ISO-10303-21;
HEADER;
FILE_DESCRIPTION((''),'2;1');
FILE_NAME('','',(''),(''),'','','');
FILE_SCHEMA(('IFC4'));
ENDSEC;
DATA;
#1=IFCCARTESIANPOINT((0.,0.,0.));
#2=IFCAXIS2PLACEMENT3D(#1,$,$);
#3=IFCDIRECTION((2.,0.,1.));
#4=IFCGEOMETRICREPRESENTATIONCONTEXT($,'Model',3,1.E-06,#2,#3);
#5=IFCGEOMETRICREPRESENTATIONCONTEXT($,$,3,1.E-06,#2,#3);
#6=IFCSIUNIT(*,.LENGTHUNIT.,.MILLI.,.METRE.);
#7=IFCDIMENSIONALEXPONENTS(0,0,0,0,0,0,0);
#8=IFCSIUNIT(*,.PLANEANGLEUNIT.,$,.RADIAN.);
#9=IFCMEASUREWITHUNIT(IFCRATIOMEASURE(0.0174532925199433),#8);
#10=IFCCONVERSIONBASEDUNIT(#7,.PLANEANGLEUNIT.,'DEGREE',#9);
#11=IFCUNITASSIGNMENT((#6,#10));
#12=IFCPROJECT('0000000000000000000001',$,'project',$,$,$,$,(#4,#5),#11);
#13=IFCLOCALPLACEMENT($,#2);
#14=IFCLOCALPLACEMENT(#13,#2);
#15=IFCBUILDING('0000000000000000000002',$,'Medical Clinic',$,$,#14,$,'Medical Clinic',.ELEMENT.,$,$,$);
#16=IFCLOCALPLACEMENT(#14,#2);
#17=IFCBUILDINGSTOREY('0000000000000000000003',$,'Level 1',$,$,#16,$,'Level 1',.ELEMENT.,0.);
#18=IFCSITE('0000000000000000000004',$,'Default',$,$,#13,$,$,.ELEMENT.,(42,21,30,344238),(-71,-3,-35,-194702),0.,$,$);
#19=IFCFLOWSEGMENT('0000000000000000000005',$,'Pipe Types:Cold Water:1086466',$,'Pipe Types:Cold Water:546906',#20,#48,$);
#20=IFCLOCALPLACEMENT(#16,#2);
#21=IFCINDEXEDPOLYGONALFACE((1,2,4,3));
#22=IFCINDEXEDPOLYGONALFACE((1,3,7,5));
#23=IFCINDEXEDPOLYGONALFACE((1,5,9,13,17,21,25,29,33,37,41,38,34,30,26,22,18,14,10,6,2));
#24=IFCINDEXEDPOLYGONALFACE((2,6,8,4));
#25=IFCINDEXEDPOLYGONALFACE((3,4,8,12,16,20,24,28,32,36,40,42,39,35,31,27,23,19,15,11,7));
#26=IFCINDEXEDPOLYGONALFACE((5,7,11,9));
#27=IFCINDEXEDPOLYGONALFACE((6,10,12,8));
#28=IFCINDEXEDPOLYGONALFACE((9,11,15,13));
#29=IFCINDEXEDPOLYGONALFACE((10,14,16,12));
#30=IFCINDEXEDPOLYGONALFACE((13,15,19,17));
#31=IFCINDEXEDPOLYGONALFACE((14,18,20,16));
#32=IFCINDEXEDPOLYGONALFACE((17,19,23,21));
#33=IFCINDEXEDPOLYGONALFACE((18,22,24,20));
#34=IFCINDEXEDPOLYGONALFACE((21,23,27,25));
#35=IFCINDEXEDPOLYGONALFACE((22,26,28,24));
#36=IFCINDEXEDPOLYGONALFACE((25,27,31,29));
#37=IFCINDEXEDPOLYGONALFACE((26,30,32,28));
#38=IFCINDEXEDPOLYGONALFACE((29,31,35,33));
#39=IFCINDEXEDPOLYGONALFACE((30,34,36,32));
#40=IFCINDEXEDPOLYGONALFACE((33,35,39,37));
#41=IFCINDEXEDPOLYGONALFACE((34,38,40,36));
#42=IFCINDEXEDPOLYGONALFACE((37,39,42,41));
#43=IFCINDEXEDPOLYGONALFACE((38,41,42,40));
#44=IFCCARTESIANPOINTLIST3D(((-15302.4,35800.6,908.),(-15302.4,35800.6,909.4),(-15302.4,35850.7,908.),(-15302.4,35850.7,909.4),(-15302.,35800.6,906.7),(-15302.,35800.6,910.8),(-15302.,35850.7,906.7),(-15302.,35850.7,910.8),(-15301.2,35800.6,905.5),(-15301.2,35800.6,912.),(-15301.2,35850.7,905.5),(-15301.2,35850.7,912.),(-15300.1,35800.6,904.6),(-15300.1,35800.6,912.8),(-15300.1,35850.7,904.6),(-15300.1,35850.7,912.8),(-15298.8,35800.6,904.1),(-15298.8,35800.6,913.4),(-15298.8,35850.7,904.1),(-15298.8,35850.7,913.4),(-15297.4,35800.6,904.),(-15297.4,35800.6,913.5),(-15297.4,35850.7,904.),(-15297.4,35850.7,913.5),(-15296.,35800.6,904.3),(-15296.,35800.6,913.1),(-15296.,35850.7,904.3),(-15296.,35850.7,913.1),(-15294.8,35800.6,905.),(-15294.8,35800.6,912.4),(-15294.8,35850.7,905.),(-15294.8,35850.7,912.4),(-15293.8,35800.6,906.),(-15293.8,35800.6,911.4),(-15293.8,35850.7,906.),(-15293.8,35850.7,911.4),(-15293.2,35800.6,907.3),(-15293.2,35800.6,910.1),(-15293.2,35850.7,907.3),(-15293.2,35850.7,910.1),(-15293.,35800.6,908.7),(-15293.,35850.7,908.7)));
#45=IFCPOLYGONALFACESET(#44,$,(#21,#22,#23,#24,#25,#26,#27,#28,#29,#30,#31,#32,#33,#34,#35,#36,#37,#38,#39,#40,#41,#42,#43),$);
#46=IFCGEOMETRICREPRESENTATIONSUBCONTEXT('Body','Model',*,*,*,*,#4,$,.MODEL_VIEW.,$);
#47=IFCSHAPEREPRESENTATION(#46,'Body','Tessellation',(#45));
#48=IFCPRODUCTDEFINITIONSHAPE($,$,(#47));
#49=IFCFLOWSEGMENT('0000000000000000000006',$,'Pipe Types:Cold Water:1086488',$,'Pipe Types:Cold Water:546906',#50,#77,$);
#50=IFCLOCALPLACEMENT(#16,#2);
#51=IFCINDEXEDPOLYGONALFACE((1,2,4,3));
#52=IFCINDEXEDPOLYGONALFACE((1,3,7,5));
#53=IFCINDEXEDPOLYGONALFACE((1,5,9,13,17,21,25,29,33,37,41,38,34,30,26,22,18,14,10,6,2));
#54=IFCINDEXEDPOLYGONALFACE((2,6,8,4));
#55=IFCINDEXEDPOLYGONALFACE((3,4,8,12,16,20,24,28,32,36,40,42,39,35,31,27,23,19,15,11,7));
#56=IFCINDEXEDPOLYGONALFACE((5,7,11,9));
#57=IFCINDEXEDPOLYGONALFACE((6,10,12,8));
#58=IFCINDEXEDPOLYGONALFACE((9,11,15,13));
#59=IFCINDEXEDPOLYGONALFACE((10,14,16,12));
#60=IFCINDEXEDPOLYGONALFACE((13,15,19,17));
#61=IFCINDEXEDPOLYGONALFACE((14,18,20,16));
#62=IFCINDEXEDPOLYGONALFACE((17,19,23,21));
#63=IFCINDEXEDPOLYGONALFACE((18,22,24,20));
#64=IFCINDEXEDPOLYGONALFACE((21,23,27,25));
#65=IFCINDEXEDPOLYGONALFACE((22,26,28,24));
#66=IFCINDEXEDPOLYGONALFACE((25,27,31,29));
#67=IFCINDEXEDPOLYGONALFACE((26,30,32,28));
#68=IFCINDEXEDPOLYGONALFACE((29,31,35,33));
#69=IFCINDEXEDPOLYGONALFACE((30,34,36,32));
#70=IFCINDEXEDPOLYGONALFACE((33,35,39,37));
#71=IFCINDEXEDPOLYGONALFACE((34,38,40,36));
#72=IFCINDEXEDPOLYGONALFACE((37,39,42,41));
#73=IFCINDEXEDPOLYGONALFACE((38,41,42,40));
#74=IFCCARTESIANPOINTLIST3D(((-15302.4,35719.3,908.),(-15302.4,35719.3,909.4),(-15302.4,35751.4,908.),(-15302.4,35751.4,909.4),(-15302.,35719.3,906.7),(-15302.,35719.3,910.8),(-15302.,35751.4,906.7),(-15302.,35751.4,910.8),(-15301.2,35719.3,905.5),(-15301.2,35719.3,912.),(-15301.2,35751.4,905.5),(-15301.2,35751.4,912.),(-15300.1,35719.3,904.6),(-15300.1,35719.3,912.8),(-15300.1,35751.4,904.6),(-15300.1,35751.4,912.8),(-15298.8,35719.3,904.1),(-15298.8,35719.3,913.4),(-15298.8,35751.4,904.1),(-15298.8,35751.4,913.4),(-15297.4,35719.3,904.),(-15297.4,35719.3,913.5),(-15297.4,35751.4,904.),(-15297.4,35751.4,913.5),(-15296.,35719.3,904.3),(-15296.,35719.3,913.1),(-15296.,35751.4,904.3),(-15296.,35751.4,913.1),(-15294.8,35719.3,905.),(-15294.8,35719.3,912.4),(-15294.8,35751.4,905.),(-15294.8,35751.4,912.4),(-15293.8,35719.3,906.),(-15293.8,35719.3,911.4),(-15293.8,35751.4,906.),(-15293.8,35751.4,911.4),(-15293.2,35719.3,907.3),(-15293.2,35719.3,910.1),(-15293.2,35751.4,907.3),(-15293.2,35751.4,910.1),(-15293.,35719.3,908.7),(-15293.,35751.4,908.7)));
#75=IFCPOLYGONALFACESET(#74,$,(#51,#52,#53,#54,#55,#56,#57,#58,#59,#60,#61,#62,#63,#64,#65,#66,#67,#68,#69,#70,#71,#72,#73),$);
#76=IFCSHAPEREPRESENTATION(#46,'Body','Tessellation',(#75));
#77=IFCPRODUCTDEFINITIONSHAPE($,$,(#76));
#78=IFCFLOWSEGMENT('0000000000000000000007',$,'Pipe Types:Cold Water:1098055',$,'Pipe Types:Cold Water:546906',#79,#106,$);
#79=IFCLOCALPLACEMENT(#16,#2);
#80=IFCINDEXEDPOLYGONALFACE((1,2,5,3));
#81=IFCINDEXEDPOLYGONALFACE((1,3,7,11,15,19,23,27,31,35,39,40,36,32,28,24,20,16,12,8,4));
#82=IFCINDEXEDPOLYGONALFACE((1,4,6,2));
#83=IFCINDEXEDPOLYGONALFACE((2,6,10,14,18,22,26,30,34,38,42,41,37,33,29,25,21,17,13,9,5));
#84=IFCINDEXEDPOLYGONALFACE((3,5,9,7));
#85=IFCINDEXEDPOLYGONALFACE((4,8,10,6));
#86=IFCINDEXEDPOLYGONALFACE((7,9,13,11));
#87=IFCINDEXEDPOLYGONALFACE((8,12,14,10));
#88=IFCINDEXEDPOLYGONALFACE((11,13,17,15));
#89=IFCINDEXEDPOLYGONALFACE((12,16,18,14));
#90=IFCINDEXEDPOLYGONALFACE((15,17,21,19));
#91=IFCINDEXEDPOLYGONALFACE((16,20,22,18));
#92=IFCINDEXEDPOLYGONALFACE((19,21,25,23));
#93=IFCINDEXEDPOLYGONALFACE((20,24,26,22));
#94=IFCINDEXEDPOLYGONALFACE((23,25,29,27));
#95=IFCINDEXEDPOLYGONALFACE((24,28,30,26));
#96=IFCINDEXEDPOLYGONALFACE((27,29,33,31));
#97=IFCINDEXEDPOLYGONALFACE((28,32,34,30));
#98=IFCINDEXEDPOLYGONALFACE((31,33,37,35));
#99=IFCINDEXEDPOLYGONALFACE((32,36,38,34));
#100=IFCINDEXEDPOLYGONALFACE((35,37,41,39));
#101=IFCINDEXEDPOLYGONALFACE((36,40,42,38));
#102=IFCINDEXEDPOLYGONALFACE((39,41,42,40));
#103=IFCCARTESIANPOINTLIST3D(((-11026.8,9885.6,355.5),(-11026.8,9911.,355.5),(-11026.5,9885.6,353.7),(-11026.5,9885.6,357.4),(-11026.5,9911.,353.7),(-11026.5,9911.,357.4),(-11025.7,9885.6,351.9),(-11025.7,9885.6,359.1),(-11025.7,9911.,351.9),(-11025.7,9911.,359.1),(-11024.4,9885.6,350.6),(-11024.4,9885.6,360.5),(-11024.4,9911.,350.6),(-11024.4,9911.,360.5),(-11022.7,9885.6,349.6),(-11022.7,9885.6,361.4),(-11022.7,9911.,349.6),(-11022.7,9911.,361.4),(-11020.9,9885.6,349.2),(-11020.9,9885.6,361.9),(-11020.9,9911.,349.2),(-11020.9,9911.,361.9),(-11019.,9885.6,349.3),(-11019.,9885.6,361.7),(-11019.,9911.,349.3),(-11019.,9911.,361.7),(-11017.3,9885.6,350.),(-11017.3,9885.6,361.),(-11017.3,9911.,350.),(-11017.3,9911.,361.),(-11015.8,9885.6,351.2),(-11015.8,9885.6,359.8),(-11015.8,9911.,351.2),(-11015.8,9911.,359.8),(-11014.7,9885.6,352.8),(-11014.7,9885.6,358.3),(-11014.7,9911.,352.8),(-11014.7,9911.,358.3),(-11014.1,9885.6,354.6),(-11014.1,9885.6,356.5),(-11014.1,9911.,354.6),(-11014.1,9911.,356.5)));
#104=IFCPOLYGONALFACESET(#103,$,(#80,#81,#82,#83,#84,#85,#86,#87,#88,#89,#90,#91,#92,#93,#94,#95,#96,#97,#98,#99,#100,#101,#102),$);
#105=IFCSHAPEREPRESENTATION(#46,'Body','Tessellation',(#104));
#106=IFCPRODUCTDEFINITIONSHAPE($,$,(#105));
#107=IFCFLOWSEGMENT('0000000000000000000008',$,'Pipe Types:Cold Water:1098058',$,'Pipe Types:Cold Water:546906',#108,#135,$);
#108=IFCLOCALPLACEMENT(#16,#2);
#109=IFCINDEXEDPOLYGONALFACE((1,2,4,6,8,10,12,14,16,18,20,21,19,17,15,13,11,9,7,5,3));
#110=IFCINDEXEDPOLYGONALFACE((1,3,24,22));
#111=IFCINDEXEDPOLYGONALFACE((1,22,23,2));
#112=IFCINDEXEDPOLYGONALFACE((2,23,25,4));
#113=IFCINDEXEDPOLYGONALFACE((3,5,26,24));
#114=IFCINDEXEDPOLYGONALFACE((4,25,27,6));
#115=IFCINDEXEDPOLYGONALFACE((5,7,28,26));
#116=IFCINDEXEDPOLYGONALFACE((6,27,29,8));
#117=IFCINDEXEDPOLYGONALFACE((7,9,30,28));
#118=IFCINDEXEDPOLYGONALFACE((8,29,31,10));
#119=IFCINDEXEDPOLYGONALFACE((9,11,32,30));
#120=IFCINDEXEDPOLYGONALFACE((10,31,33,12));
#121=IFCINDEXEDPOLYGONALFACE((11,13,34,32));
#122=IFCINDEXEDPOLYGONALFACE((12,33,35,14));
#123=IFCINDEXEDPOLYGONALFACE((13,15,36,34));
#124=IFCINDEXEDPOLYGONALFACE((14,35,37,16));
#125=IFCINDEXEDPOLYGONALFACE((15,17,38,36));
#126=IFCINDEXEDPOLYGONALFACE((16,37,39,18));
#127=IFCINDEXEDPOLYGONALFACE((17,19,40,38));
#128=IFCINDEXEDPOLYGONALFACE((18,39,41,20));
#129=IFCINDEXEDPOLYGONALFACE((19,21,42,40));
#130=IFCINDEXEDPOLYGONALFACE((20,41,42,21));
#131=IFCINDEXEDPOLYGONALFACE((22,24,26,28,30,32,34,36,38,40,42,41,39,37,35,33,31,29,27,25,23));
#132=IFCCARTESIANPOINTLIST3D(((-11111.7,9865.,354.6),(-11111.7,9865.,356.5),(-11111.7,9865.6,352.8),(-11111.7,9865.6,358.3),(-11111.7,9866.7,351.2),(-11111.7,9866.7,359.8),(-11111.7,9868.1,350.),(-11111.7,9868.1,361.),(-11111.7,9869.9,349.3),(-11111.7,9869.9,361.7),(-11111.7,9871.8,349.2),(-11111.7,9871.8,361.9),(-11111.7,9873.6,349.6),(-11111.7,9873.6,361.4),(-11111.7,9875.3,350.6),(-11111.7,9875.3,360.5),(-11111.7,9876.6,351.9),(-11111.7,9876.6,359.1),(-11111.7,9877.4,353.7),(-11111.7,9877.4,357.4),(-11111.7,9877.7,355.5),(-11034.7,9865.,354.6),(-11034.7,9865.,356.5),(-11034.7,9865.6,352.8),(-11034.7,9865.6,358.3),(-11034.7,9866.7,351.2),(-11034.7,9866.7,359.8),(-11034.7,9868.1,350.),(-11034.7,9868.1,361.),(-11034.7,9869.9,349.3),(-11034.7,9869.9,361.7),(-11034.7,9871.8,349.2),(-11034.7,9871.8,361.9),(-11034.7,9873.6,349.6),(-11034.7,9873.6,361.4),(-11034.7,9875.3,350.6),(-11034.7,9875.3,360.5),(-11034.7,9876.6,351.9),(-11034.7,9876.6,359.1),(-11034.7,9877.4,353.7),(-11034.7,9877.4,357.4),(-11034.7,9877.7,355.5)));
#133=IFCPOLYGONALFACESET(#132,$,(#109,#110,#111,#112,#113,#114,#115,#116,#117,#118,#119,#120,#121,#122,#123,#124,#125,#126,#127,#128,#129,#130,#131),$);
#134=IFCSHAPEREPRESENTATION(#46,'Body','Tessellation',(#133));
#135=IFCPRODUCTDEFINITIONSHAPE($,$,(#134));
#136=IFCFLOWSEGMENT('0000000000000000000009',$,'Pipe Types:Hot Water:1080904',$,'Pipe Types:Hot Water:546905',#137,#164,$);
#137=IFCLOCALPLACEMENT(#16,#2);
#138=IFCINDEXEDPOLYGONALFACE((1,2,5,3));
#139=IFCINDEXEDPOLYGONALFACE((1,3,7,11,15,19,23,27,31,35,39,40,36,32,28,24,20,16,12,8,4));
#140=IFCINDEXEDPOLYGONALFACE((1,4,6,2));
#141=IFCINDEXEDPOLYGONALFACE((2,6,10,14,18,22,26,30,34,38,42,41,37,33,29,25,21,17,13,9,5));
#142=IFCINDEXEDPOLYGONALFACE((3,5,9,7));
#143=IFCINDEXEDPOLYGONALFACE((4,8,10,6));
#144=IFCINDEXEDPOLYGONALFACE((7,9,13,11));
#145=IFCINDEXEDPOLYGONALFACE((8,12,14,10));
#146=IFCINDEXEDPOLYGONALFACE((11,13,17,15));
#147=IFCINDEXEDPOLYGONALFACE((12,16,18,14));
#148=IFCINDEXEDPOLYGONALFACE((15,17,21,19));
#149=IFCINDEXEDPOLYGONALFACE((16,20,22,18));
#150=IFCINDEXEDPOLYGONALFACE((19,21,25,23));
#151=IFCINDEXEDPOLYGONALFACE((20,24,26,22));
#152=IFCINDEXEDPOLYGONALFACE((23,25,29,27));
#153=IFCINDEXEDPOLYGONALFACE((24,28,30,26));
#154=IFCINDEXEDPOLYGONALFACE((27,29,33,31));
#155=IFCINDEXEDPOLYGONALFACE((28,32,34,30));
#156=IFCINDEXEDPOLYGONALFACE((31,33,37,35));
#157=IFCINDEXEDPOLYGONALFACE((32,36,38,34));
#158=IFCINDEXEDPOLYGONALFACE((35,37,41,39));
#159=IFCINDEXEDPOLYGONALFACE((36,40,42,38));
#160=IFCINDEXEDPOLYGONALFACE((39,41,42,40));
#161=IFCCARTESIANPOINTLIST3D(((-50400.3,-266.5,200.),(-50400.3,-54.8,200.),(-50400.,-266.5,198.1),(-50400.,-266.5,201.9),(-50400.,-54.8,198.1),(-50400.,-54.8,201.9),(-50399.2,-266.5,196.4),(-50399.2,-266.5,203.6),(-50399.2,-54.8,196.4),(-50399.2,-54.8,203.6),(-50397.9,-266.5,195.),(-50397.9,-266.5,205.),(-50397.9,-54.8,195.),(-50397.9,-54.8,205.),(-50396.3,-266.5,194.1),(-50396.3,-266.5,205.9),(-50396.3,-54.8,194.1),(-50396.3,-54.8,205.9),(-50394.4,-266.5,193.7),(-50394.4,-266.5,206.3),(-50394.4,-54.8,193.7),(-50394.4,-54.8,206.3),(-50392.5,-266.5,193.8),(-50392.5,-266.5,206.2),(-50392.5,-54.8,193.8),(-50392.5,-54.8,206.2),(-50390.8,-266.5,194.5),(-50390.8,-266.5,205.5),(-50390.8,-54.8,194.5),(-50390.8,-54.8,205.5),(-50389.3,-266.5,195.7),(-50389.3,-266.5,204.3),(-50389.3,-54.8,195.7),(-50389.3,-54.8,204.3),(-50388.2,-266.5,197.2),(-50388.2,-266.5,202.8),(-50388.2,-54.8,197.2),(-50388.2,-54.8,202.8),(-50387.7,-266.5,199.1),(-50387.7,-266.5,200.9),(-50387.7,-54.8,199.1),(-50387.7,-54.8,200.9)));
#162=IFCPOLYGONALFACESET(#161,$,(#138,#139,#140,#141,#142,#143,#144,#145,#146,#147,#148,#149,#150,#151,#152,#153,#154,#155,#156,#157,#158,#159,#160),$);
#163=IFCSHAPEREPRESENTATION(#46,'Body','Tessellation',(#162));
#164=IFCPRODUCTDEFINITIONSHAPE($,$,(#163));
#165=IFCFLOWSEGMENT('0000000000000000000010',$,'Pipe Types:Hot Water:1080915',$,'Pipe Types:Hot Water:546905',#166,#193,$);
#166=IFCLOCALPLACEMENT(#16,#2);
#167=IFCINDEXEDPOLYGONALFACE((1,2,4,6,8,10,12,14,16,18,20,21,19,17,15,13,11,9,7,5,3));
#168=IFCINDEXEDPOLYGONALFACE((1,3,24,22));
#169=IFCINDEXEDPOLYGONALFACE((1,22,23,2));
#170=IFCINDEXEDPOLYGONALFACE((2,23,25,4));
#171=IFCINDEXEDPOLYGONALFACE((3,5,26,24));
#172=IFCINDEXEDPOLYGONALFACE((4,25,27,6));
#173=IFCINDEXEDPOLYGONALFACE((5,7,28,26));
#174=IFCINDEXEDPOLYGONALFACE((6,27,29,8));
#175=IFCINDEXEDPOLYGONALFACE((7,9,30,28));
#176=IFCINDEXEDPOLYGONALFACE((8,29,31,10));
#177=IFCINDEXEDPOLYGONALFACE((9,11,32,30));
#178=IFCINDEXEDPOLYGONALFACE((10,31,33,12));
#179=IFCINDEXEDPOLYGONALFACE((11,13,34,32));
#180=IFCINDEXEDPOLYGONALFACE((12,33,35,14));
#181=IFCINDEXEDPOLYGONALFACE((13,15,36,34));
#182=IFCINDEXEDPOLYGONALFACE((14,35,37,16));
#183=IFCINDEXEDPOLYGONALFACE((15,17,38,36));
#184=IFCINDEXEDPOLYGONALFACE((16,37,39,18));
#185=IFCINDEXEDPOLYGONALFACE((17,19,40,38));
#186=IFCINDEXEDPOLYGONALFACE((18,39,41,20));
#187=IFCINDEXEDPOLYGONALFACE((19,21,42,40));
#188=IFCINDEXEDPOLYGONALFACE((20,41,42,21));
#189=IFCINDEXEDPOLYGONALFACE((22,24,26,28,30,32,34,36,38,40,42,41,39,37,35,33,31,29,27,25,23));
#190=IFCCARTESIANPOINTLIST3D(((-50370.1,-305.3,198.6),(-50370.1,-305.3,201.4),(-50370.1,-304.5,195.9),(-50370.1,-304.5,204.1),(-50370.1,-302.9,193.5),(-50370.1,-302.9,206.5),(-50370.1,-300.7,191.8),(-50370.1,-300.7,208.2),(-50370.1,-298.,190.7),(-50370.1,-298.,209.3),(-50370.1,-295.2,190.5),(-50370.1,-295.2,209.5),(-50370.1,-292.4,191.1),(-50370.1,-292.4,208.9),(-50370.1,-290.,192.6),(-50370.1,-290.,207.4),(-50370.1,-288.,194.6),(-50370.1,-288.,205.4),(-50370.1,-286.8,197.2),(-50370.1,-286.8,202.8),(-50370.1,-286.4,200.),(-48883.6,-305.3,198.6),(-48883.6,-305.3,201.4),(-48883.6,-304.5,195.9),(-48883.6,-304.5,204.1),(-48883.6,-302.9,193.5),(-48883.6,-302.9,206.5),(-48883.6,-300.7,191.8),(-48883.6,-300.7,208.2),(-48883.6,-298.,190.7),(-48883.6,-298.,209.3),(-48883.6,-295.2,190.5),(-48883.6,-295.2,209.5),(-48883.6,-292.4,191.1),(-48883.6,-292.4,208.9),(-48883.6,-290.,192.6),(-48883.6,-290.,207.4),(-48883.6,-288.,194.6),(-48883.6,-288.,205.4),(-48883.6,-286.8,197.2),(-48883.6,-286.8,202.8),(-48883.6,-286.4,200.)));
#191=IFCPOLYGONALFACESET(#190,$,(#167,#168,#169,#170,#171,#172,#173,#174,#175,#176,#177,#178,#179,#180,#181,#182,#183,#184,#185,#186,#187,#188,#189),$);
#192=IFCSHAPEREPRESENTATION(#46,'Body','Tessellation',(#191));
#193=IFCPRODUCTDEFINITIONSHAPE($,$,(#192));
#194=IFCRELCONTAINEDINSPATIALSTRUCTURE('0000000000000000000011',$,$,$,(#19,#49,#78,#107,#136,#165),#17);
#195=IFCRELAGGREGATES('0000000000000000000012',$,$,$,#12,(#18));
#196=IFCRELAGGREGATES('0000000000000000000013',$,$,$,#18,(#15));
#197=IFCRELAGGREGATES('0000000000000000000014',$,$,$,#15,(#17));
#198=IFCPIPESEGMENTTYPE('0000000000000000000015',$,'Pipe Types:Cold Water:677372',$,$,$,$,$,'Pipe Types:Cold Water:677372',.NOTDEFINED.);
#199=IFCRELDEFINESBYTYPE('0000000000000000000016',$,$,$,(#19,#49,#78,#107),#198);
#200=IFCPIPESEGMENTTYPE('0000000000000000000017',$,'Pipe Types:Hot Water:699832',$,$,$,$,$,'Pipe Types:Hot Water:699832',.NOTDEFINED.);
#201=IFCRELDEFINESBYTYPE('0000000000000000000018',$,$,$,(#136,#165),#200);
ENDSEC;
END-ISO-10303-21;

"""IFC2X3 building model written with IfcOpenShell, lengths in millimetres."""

from ifc_helpers import new_model, entity, si_unit, converted_unit, direction, frame, frame_2d, origin, origin_2d_with_axis, place, context, subcontext, project, spatial, circle, extrude, type_object, element, save


model = new_model("IFC2X3")

# Units and contexts
model_context = context("Model", 3, precision=1e-06, world=origin(), true_north=direction((2.0, 0.0, 1.0)))
context_of_model = context(None, 3, precision=1e-06, world=origin(), true_north=direction((2.0, 0.0, 1.0)))
body_context = subcontext(model_context, "Body", "Model", "MODEL_VIEW")
ifc_project = project(units=[si_unit("LENGTHUNIT", "METRE", prefix="MILLI"), converted_unit("PLANEANGLEUNIT", "DEGREE", entity("IfcRatioMeasure", 0.0174532925199433), si_unit("PLANEANGLEUNIT", "RADIAN"), dimensions=[0, 0, 0, 0, 0, 0, 0])], contexts=[model_context, context_of_model])

# Site, building, storey
site_placement = place(None, origin())
site = spatial("IfcSite", under=ifc_project, at=site_placement, Name="Default", CompositionType="ELEMENT", RefLatitude=(42, 21, 30, 344238), RefLongitude=(-71, -3, -35, -194702), RefElevation=0.0)
building_placement = place(site_placement, origin())
building = spatial("IfcBuilding", under=site, at=building_placement, Name="Medical Clinic", LongName="Medical Clinic", CompositionType="ELEMENT")
storey_placement = place(building_placement, origin())
storey = spatial("IfcBuildingStorey", under=building, at=storey_placement, Name="Level 1", LongName="Level 1", CompositionType="ELEMENT", Elevation=0.0)

# Flow segments
pipe_segment_type_1 = type_object("IfcPipeSegmentType", Name="Pipe Types:Cold Water:677372", ElementType="Pipe Types:Cold Water:677372", PredefinedType="NOTDEFINED")
flow_segment_1_placement = place(storey_placement, origin())
element("IfcFlowSegment", 1, at=flow_segment_1_placement, inside=storey, type_object=pipe_segment_type_1, Name="Pipe Types:Cold Water:1086466", ObjectType="Pipe Types:Cold Water:546906", context=body_context, shape_type="SweptSolid", body=[
    extrude(circle(Radius=4.8, at=origin_2d_with_axis()), frame((-15297.7, 35800.6, 908.7), z_axis=(0.0, 1.0, 0.0), x_axis=(1.0, 0.0, 0.0)), (0.0, 0.0, 1.0), 50.1),
])
flow_segment_2_placement = place(storey_placement, origin())
element("IfcFlowSegment", 2, at=flow_segment_2_placement, inside=storey, type_object=pipe_segment_type_1, Name="Pipe Types:Cold Water:1086488", ObjectType="Pipe Types:Cold Water:546906", context=body_context, shape_type="SweptSolid", body=[
    extrude(circle(Radius=4.8, at=frame_2d((0.0, 0.0), x_axis=(1.0, 0.0))), frame((-15297.7, 35719.3, 908.7), z_axis=(0.0, 1.0, 0.0), x_axis=(1.0, 0.0, 0.0)), (0.0, 0.0, 1.0), 32.1),
])
flow_segment_3_placement = place(storey_placement, origin())
element("IfcFlowSegment", 3, at=flow_segment_3_placement, inside=storey, type_object=pipe_segment_type_1, Name="Pipe Types:Cold Water:1098055", ObjectType="Pipe Types:Cold Water:546906", context=body_context, shape_type="SweptSolid", body=[
    extrude(circle(Radius=6.3, at=frame_2d((0.0, 0.0), x_axis=(1.0, 0.0))), frame((-11020.4, 9885.6, 355.5), z_axis=(0.0, 1.0, 0.0), x_axis=(-1.0, 0.0, 0.0)), (0.0, 0.0, 1.0), 25.4),
])
flow_segment_4_placement = place(storey_placement, origin())
element("IfcFlowSegment", 4, at=flow_segment_4_placement, inside=storey, type_object=pipe_segment_type_1, Name="Pipe Types:Cold Water:1098058", ObjectType="Pipe Types:Cold Water:546906", context=body_context, shape_type="SweptSolid", body=[
    extrude(circle(Radius=6.3, at=frame_2d((0.0, 0.0), x_axis=(1.0, 0.0))), frame((-11111.7, 9871.3, 355.5), z_axis=(1.0, 0.0, 0.0), x_axis=(0.0, 1.0, 0.0)), (0.0, 0.0, 1.0), 77.0),
])
pipe_segment_type_2 = type_object("IfcPipeSegmentType", Name="Pipe Types:Hot Water:699832", ElementType="Pipe Types:Hot Water:699832", PredefinedType="NOTDEFINED")
flow_segment_5_placement = place(storey_placement, origin())
element("IfcFlowSegment", 5, at=flow_segment_5_placement, inside=storey, type_object=pipe_segment_type_2, Name="Pipe Types:Hot Water:1080904", ObjectType="Pipe Types:Hot Water:546905", context=body_context, shape_type="SweptSolid", body=[
    extrude(circle(Radius=6.3, at=frame_2d((0.0, 0.0), x_axis=(1.0, 0.0))), frame((-50394.0, -266.5, 200.0), z_axis=(0.0, 1.0, 0.0), x_axis=(-1.0, 0.0, 0.0)), (0.0, 0.0, 1.0), 211.7),
])
flow_segment_6_placement = place(storey_placement, origin())
element("IfcFlowSegment", 6, at=flow_segment_6_placement, inside=storey, type_object=pipe_segment_type_2, Name="Pipe Types:Hot Water:1080915", ObjectType="Pipe Types:Hot Water:546905", context=body_context, shape_type="SweptSolid", body=[
    extrude(circle(Radius=9.5, at=frame_2d((0.0, 0.0), x_axis=(1.0, 0.0))), frame((-50370.1, -295.9, 200.0), z_axis=(1.0, 0.0, 0.0), x_axis=(0.0, 1.0, 0.0)), (0.0, 0.0, 1.0), 1486.5),
])

save(model, "model.ifc")
